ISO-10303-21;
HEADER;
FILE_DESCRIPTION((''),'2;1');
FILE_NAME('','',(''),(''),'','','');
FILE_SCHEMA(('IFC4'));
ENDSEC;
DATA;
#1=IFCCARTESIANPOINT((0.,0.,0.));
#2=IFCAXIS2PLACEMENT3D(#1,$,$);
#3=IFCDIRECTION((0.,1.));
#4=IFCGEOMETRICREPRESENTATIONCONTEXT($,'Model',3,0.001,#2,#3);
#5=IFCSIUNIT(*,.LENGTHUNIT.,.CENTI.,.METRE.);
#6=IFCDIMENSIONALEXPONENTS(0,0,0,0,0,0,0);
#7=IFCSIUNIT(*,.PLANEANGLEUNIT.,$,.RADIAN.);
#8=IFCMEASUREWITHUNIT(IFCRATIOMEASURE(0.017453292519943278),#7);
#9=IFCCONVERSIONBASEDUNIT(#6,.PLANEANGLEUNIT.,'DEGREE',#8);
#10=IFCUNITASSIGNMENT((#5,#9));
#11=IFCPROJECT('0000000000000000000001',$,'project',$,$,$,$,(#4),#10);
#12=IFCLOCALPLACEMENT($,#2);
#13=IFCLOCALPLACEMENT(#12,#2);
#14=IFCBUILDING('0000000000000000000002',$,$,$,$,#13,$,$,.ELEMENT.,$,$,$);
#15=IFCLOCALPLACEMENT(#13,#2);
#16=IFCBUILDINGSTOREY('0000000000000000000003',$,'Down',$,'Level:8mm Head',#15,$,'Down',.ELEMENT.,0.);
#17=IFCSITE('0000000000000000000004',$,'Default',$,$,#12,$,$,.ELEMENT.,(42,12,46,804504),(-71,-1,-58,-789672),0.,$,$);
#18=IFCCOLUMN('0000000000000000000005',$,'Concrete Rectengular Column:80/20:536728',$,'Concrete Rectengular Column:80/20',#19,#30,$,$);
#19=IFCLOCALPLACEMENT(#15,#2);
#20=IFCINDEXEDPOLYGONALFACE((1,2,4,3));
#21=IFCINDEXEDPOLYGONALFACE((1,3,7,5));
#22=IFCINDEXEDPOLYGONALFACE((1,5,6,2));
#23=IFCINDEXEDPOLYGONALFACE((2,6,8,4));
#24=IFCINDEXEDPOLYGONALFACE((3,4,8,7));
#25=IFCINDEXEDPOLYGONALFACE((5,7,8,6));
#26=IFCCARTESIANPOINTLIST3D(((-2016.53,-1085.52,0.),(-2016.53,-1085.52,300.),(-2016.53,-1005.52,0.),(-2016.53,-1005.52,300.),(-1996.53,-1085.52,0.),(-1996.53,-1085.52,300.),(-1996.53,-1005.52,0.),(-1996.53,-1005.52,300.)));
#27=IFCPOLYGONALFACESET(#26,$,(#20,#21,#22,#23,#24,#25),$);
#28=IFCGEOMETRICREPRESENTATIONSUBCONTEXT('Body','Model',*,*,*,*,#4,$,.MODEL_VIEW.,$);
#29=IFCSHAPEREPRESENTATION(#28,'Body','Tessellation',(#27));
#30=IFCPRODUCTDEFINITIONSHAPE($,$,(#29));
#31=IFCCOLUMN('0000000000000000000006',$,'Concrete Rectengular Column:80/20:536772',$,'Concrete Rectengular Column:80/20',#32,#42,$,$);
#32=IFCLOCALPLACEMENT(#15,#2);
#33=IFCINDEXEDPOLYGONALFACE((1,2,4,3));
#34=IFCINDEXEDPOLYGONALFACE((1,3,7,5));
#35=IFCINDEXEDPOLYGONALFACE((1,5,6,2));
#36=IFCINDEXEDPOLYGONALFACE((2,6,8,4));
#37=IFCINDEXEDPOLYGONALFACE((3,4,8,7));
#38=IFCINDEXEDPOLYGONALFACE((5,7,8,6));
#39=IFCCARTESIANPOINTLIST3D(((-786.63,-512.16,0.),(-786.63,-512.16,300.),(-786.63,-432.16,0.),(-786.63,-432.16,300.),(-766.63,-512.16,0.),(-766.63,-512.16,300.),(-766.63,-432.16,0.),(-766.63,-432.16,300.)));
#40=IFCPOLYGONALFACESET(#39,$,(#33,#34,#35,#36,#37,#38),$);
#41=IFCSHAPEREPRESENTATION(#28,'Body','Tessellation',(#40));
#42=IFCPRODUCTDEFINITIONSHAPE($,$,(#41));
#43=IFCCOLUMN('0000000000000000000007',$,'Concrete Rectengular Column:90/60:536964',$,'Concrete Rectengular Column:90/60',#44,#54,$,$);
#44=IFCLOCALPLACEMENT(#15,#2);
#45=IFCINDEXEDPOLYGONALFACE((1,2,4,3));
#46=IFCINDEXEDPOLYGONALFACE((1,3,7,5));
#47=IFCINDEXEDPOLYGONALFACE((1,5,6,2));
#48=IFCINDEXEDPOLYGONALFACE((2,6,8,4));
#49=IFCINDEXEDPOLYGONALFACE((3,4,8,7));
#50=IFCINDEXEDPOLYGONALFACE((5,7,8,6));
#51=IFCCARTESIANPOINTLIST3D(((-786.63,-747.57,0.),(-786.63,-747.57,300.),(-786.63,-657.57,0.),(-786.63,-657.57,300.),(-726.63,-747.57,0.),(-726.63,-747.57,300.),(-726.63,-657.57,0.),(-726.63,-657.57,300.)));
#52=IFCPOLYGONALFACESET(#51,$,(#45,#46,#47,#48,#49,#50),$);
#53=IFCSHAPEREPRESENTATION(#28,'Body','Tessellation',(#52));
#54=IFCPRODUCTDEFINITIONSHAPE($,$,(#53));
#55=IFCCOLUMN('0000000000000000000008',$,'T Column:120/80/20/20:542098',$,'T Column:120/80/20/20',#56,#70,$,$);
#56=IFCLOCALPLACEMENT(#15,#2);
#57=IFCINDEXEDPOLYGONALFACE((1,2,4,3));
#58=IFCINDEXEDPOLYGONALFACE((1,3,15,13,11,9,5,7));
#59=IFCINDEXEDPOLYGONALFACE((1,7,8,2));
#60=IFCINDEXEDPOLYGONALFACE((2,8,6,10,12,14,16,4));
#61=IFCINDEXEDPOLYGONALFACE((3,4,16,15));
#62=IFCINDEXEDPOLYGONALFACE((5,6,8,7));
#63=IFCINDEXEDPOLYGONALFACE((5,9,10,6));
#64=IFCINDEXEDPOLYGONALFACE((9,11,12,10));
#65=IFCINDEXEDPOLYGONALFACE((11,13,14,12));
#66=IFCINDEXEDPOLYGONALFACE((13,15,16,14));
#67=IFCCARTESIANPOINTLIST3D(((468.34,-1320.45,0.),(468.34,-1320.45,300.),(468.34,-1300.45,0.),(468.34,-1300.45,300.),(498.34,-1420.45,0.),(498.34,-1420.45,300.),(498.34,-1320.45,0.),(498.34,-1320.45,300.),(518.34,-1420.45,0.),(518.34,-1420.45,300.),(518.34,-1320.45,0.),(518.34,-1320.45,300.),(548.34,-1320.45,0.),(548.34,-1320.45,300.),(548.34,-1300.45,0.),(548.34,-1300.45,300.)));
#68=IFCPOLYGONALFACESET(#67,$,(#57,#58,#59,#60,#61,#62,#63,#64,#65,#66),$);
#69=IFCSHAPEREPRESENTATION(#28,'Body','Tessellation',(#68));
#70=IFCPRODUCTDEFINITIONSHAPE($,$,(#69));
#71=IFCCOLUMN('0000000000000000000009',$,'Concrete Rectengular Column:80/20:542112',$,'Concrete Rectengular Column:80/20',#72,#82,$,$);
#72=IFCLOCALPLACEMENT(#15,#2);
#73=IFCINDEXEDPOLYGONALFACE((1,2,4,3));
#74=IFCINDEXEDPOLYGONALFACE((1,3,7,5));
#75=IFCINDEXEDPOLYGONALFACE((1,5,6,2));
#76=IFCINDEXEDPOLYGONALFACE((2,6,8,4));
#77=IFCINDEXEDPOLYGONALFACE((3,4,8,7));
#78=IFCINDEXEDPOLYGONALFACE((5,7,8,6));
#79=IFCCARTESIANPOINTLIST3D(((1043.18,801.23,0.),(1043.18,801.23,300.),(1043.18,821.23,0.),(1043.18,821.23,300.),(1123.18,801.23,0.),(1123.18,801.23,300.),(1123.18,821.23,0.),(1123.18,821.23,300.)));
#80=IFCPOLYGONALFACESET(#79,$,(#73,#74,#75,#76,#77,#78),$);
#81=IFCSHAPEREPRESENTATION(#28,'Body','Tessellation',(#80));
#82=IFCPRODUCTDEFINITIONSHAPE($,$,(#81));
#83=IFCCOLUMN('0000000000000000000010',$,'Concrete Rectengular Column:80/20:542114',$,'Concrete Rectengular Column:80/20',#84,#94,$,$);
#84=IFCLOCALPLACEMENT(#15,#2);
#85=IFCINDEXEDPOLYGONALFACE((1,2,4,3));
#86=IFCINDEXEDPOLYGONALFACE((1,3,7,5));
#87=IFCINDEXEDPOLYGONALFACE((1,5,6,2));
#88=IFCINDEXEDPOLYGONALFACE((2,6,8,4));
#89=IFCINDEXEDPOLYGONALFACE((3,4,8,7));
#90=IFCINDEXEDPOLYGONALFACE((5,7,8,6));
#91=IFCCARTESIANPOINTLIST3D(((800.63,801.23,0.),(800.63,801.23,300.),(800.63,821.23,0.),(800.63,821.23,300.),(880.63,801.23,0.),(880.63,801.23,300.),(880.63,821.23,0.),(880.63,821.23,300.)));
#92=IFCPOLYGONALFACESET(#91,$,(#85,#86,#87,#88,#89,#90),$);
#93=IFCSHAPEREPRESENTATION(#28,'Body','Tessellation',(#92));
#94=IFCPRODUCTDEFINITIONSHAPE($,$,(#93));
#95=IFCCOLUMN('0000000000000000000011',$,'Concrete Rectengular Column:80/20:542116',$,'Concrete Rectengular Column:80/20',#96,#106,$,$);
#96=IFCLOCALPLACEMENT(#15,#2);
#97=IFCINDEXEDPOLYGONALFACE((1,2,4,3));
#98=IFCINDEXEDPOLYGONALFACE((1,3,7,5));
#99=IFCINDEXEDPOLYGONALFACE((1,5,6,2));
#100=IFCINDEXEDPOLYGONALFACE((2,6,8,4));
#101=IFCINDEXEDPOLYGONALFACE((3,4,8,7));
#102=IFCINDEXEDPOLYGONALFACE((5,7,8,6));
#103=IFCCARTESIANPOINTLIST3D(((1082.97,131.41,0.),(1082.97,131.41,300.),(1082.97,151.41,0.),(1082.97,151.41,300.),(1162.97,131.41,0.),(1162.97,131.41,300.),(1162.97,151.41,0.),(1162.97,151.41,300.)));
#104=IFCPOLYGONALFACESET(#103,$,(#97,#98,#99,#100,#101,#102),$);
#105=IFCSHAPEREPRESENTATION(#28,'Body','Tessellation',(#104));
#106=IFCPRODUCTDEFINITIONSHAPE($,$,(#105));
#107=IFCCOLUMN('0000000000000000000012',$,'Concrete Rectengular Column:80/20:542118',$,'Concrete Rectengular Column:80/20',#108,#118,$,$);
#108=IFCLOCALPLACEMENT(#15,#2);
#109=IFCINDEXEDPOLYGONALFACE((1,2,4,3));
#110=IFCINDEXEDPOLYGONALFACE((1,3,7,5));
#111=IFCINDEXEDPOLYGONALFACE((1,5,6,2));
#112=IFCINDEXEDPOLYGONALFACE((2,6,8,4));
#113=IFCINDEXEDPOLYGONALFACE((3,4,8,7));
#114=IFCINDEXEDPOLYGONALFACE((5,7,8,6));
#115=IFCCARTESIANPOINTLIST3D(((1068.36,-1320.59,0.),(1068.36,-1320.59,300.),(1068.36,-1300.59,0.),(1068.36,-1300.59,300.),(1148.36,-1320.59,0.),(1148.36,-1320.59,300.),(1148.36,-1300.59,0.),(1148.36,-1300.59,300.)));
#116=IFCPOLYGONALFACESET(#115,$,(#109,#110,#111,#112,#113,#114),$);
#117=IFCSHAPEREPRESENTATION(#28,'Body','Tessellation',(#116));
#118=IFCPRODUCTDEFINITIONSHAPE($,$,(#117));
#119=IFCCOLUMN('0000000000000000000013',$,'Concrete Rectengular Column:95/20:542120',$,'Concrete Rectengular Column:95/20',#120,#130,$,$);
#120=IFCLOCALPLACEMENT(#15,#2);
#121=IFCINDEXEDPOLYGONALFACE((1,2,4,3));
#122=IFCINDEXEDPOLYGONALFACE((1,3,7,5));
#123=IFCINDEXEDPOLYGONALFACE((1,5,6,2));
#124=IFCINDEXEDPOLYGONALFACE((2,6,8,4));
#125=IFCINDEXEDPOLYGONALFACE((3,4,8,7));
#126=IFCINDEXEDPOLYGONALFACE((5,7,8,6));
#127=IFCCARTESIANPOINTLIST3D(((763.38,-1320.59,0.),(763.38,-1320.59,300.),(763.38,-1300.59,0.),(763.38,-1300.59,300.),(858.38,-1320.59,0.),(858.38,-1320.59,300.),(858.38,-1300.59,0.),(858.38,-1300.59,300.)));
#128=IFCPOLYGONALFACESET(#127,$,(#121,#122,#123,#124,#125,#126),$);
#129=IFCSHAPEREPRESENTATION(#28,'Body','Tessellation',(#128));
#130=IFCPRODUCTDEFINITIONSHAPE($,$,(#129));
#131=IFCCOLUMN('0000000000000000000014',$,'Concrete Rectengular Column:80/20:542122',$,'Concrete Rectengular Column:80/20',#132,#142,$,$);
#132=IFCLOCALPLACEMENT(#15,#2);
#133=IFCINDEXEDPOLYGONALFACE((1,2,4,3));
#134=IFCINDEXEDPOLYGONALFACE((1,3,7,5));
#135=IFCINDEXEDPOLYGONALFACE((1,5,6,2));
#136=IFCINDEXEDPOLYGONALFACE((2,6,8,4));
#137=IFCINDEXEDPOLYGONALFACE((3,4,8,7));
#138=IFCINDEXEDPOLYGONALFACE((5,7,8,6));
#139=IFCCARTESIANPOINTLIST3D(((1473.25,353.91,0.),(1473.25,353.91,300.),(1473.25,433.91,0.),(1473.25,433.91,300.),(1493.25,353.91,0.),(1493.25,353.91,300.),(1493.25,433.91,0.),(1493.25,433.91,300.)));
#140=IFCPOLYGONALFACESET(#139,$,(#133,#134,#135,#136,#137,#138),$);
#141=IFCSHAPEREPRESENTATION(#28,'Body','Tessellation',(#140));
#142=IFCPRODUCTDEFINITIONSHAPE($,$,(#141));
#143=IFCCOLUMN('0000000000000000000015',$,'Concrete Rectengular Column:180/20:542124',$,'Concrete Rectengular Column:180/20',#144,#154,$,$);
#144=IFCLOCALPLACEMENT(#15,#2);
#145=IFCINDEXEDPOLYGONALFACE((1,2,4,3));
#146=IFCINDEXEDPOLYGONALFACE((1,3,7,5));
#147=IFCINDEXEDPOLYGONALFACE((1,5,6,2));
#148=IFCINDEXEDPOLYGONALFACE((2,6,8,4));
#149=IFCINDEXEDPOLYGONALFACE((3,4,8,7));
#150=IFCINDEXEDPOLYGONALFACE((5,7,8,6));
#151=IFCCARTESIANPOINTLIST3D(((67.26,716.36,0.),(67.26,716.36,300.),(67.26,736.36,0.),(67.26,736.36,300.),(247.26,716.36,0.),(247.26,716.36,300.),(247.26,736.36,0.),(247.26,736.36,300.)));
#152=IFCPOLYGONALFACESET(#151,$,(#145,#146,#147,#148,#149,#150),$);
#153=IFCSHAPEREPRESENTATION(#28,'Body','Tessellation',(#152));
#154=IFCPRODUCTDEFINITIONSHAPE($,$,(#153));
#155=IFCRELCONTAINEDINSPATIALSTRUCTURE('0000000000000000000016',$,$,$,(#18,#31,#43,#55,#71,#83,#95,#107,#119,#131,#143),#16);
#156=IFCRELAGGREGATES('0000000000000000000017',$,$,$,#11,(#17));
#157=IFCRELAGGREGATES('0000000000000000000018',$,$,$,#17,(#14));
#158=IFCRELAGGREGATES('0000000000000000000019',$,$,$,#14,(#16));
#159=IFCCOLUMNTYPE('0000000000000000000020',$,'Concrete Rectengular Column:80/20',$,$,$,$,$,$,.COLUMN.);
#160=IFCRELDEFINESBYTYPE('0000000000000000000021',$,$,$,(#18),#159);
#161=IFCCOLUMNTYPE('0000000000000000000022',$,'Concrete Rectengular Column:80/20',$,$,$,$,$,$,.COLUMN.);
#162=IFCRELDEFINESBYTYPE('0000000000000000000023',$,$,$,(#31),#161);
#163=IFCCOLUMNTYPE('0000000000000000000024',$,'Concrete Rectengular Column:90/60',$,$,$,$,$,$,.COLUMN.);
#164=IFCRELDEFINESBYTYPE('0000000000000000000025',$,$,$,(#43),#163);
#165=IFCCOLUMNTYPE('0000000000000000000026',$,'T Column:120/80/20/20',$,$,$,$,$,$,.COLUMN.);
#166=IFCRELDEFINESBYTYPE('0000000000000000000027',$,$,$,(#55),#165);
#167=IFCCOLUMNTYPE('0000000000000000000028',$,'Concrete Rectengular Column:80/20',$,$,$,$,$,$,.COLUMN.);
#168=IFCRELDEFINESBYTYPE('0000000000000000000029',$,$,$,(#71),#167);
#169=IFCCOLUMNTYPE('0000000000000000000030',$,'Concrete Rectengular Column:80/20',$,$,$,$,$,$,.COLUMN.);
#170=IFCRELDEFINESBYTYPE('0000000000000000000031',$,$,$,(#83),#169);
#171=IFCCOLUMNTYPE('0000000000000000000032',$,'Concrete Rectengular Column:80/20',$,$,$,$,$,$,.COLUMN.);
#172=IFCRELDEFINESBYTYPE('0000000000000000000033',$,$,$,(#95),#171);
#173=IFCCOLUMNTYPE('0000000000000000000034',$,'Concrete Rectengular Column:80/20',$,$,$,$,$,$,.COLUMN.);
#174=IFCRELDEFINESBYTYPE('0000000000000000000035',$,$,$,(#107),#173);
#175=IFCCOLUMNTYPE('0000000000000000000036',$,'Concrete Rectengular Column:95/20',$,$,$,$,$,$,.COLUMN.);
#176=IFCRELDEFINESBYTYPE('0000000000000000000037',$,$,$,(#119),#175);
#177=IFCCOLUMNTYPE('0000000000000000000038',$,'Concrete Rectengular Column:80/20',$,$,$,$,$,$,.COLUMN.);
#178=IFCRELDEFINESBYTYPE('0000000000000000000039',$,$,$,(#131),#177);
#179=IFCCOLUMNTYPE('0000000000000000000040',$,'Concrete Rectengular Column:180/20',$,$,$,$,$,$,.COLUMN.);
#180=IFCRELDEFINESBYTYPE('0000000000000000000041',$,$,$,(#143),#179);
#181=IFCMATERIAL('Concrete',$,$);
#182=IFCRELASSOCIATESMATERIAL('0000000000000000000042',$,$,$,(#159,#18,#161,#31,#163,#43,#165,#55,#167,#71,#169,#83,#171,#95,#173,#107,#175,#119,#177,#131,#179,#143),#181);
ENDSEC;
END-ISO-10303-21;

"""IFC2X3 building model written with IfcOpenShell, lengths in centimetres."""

from ifc_helpers import new_model, entity, si_unit, converted_unit, direction, frame, frame_2d, origin, origin_2d_with_axis, place, context, subcontext, project, spatial, polyline, rectangle, outline, extrude, source, transform, mapped, material, type_object, type_shapes, element, save


model = new_model("IFC2X3")

# Units and contexts
model_context = context("Model", 3, precision=0.001, world=origin(), true_north=direction((0.0, 1.0)))
body_context = subcontext(model_context, "Body", "Model", "MODEL_VIEW")
ifc_project = project(units=[si_unit("LENGTHUNIT", "METRE", prefix="CENTI"), converted_unit("PLANEANGLEUNIT", "DEGREE", entity("IfcRatioMeasure", 0.017453292519943278), si_unit("PLANEANGLEUNIT", "RADIAN"), dimensions=[0, 0, 0, 0, 0, 0, 0])], contexts=[model_context])

# Site, building, storey
site_placement = place(None, origin())
site = spatial("IfcSite", under=ifc_project, at=site_placement, Name="Default", CompositionType="ELEMENT", RefLatitude=(42, 12, 46, 804504), RefLongitude=(-71, -1, -58, -789672), RefElevation=0.0)
building_placement = place(site_placement, origin())
building = spatial("IfcBuilding", under=site, at=building_placement, CompositionType="ELEMENT")
storey_placement = place(building_placement, origin())
storey = spatial("IfcBuildingStorey", under=building, at=storey_placement, Name="Down", ObjectType="Level:8mm Head", LongName="Down", CompositionType="ELEMENT", Elevation=0.0)

# Columns
ifc_material = material(Name="Concrete")
column_type_1 = type_object("IfcColumnType", Name="Concrete Rectengular Column:80/20", PredefinedType="COLUMN", material=ifc_material)
shared_shape_1 = source(origin(), body_context, "Body", "SweptSolid", [
    extrude(rectangle(XDim=80.0, YDim=20.0, at=origin_2d_with_axis()), frame((-2006.53, -1045.52, 0.0), z_axis=(0.0, 0.0, 1.0), x_axis=(0.0, -1.0, 0.0)), (0.0, 0.0, 1.0), 300.0),
])
type_shapes(column_type_1, [shared_shape_1])
column_1_placement = place(storey_placement, origin())
element("IfcColumn", 1, at=column_1_placement, inside=storey, type_object=column_type_1, material=ifc_material, Name="Concrete Rectengular Column:80/20:536728", ObjectType="Concrete Rectengular Column:80/20", context=body_context, shape_type="MappedRepresentation", body=[
    mapped(shared_shape_1, transform((0.0, 0.0, 0.0), scale=1.0)),
])
column_type_2 = type_object("IfcColumnType", Name="Concrete Rectengular Column:80/20", PredefinedType="COLUMN", material=ifc_material)
shared_shape_2 = source(origin(), body_context, "Body", "SweptSolid", [
    extrude(rectangle(XDim=80.0, YDim=20.0, at=origin_2d_with_axis()), frame((-776.63, -472.16, 0.0), z_axis=(0.0, 0.0, 1.0), x_axis=(0.0, -1.0, 0.0)), (0.0, 0.0, 1.0), 300.0),
])
type_shapes(column_type_2, [shared_shape_2])
column_2_placement = place(storey_placement, origin())
element("IfcColumn", 2, at=column_2_placement, inside=storey, type_object=column_type_2, material=ifc_material, Name="Concrete Rectengular Column:80/20:536772", ObjectType="Concrete Rectengular Column:80/20", context=body_context, shape_type="MappedRepresentation", body=[
    mapped(shared_shape_2, transform((0.0, 0.0, 0.0), scale=1.0)),
])
column_type_3 = type_object("IfcColumnType", Name="Concrete Rectengular Column:90/60", PredefinedType="COLUMN", material=ifc_material)
shared_shape_3 = source(origin(), body_context, "Body", "SweptSolid", [
    extrude(rectangle(XDim=90.0, YDim=60.0, at=frame_2d((0.0, 0.0), x_axis=(1.0, 0.0))), frame((-756.63, -702.57, 0.0), z_axis=(0.0, 0.0, 1.0), x_axis=(0.0, -1.0, 0.0)), (0.0, 0.0, 1.0), 300.0),
])
type_shapes(column_type_3, [shared_shape_3])
column_3_placement = place(storey_placement, origin())
element("IfcColumn", 3, at=column_3_placement, inside=storey, type_object=column_type_3, material=ifc_material, Name="Concrete Rectengular Column:90/60:536964", ObjectType="Concrete Rectengular Column:90/60", context=body_context, shape_type="MappedRepresentation", body=[
    mapped(shared_shape_3, transform((0.0, 0.0, 0.0), scale=1.0)),
])
column_type_4 = type_object("IfcColumnType", Name="T Column:120/80/20/20", PredefinedType="COLUMN", material=ifc_material)
shared_shape_4 = source(origin(), body_context, "Body", "SweptSolid", [
    extrude(outline(polyline([(-40.0, -40.0), (-20.0, -40.0), (-20.0, -10.0), (80.0, -10.0), (80.0, 10.0), (-20.0, 10.0), (-20.0, 40.0), (-40.0, 40.0), (-40.0, -40.0)])), frame((508.34, -1340.45, 0.0), z_axis=(0.0, 0.0, 1.0), x_axis=(0.0, -1.0, 0.0)), (0.0, 0.0, 1.0), 300.0),
])
type_shapes(column_type_4, [shared_shape_4])
column_4_placement = place(storey_placement, origin())
element("IfcColumn", 4, at=column_4_placement, inside=storey, type_object=column_type_4, material=ifc_material, Name="T Column:120/80/20/20:542098", ObjectType="T Column:120/80/20/20", context=body_context, shape_type="MappedRepresentation", body=[
    mapped(shared_shape_4, transform((0.0, 0.0, 0.0), scale=1.0)),
])
column_type_5 = type_object("IfcColumnType", Name="Concrete Rectengular Column:80/20", PredefinedType="COLUMN", material=ifc_material)
shared_shape_5 = source(origin(), body_context, "Body", "SweptSolid", [
    extrude(rectangle(XDim=20.0, YDim=80.0, at=origin_2d_with_axis()), frame((1083.18, 811.23, 0.0), z_axis=(0.0, 0.0, 1.0), x_axis=(0.0, -1.0, 0.0)), (0.0, 0.0, 1.0), 300.0),
])
type_shapes(column_type_5, [shared_shape_5])
column_5_placement = place(storey_placement, origin())
element("IfcColumn", 5, at=column_5_placement, inside=storey, type_object=column_type_5, material=ifc_material, Name="Concrete Rectengular Column:80/20:542112", ObjectType="Concrete Rectengular Column:80/20", context=body_context, shape_type="MappedRepresentation", body=[
    mapped(shared_shape_5, transform((0.0, 0.0, 0.0), scale=1.0)),
])
column_type_6 = type_object("IfcColumnType", Name="Concrete Rectengular Column:80/20", PredefinedType="COLUMN", material=ifc_material)
shared_shape_6 = source(origin(), body_context, "Body", "SweptSolid", [
    extrude(rectangle(XDim=20.0, YDim=80.0, at=frame_2d((0.0, 0.0), x_axis=(1.0, 0.0))), frame((840.63, 811.23, 0.0), z_axis=(0.0, 0.0, 1.0), x_axis=(0.0, -1.0, 0.0)), (0.0, 0.0, 1.0), 300.0),
])
type_shapes(column_type_6, [shared_shape_6])
column_6_placement = place(storey_placement, origin())
element("IfcColumn", 6, at=column_6_placement, inside=storey, type_object=column_type_6, material=ifc_material, Name="Concrete Rectengular Column:80/20:542114", ObjectType="Concrete Rectengular Column:80/20", context=body_context, shape_type="MappedRepresentation", body=[
    mapped(shared_shape_6, transform((0.0, 0.0, 0.0), scale=1.0)),
])
column_type_7 = type_object("IfcColumnType", Name="Concrete Rectengular Column:80/20", PredefinedType="COLUMN", material=ifc_material)
shared_shape_7 = source(origin(), body_context, "Body", "SweptSolid", [
    extrude(rectangle(XDim=20.0, YDim=80.0, at=frame_2d((0.0, 0.0), x_axis=(1.0, 0.0))), frame((1122.97, 141.41, 0.0), z_axis=(0.0, 0.0, 1.0), x_axis=(0.0, -1.0, 0.0)), (0.0, 0.0, 1.0), 300.0),
])
type_shapes(column_type_7, [shared_shape_7])
column_7_placement = place(storey_placement, origin())
element("IfcColumn", 7, at=column_7_placement, inside=storey, type_object=column_type_7, material=ifc_material, Name="Concrete Rectengular Column:80/20:542116", ObjectType="Concrete Rectengular Column:80/20", context=body_context, shape_type="MappedRepresentation", body=[
    mapped(shared_shape_7, transform((0.0, 0.0, 0.0), scale=1.0)),
])
column_type_8 = type_object("IfcColumnType", Name="Concrete Rectengular Column:80/20", PredefinedType="COLUMN", material=ifc_material)
shared_shape_8 = source(origin(), body_context, "Body", "SweptSolid", [
    extrude(rectangle(XDim=20.0, YDim=80.0, at=frame_2d((0.0, 0.0), x_axis=(1.0, 0.0))), frame((1108.36, -1310.59, 0.0), z_axis=(0.0, 0.0, 1.0), x_axis=(0.0, -1.0, 0.0)), (0.0, 0.0, 1.0), 300.0),
])
type_shapes(column_type_8, [shared_shape_8])
column_8_placement = place(storey_placement, origin())
element("IfcColumn", 8, at=column_8_placement, inside=storey, type_object=column_type_8, material=ifc_material, Name="Concrete Rectengular Column:80/20:542118", ObjectType="Concrete Rectengular Column:80/20", context=body_context, shape_type="MappedRepresentation", body=[
    mapped(shared_shape_8, transform((0.0, 0.0, 0.0), scale=1.0)),
])
column_type_9 = type_object("IfcColumnType", Name="Concrete Rectengular Column:95/20", PredefinedType="COLUMN", material=ifc_material)
shared_shape_9 = source(origin(), body_context, "Body", "SweptSolid", [
    extrude(rectangle(XDim=20.0, YDim=95.0, at=frame_2d((0.0, 0.0), x_axis=(1.0, 0.0))), frame((810.88, -1310.59, 0.0), z_axis=(0.0, 0.0, 1.0), x_axis=(0.0, -1.0, 0.0)), (0.0, 0.0, 1.0), 300.0),
])
type_shapes(column_type_9, [shared_shape_9])
column_9_placement = place(storey_placement, origin())
element("IfcColumn", 9, at=column_9_placement, inside=storey, type_object=column_type_9, material=ifc_material, Name="Concrete Rectengular Column:95/20:542120", ObjectType="Concrete Rectengular Column:95/20", context=body_context, shape_type="MappedRepresentation", body=[
    mapped(shared_shape_9, transform((0.0, 0.0, 0.0), scale=1.0)),
])
column_type_10 = type_object("IfcColumnType", Name="Concrete Rectengular Column:80/20", PredefinedType="COLUMN", material=ifc_material)
shared_shape_10 = source(origin(), body_context, "Body", "SweptSolid", [
    extrude(rectangle(XDim=80.0, YDim=20.0, at=frame_2d((0.0, 0.0), x_axis=(1.0, 0.0))), frame((1483.25, 393.91, 0.0), z_axis=(0.0, 0.0, 1.0), x_axis=(0.0, -1.0, 0.0)), (0.0, 0.0, 1.0), 300.0),
])
type_shapes(column_type_10, [shared_shape_10])
column_10_placement = place(storey_placement, origin())
element("IfcColumn", 10, at=column_10_placement, inside=storey, type_object=column_type_10, material=ifc_material, Name="Concrete Rectengular Column:80/20:542122", ObjectType="Concrete Rectengular Column:80/20", context=body_context, shape_type="MappedRepresentation", body=[
    mapped(shared_shape_10, transform((0.0, 0.0, 0.0), scale=1.0)),
])
column_type_11 = type_object("IfcColumnType", Name="Concrete Rectengular Column:180/20", PredefinedType="COLUMN", material=ifc_material)
shared_shape_11 = source(origin(), body_context, "Body", "SweptSolid", [
    extrude(rectangle(XDim=20.0, YDim=180.0, at=frame_2d((0.0, 0.0), x_axis=(1.0, 0.0))), frame((157.26, 726.36, 0.0), z_axis=(0.0, 0.0, 1.0), x_axis=(0.0, -1.0, 0.0)), (0.0, 0.0, 1.0), 300.0),
])
type_shapes(column_type_11, [shared_shape_11])
column_11_placement = place(storey_placement, origin())
element("IfcColumn", 11, at=column_11_placement, inside=storey, type_object=column_type_11, material=ifc_material, Name="Concrete Rectengular Column:180/20:542124", ObjectType="Concrete Rectengular Column:180/20", context=body_context, shape_type="MappedRepresentation", body=[
    mapped(shared_shape_11, transform((0.0, 0.0, 0.0), scale=1.0)),
])

save(model, "model.ifc")
